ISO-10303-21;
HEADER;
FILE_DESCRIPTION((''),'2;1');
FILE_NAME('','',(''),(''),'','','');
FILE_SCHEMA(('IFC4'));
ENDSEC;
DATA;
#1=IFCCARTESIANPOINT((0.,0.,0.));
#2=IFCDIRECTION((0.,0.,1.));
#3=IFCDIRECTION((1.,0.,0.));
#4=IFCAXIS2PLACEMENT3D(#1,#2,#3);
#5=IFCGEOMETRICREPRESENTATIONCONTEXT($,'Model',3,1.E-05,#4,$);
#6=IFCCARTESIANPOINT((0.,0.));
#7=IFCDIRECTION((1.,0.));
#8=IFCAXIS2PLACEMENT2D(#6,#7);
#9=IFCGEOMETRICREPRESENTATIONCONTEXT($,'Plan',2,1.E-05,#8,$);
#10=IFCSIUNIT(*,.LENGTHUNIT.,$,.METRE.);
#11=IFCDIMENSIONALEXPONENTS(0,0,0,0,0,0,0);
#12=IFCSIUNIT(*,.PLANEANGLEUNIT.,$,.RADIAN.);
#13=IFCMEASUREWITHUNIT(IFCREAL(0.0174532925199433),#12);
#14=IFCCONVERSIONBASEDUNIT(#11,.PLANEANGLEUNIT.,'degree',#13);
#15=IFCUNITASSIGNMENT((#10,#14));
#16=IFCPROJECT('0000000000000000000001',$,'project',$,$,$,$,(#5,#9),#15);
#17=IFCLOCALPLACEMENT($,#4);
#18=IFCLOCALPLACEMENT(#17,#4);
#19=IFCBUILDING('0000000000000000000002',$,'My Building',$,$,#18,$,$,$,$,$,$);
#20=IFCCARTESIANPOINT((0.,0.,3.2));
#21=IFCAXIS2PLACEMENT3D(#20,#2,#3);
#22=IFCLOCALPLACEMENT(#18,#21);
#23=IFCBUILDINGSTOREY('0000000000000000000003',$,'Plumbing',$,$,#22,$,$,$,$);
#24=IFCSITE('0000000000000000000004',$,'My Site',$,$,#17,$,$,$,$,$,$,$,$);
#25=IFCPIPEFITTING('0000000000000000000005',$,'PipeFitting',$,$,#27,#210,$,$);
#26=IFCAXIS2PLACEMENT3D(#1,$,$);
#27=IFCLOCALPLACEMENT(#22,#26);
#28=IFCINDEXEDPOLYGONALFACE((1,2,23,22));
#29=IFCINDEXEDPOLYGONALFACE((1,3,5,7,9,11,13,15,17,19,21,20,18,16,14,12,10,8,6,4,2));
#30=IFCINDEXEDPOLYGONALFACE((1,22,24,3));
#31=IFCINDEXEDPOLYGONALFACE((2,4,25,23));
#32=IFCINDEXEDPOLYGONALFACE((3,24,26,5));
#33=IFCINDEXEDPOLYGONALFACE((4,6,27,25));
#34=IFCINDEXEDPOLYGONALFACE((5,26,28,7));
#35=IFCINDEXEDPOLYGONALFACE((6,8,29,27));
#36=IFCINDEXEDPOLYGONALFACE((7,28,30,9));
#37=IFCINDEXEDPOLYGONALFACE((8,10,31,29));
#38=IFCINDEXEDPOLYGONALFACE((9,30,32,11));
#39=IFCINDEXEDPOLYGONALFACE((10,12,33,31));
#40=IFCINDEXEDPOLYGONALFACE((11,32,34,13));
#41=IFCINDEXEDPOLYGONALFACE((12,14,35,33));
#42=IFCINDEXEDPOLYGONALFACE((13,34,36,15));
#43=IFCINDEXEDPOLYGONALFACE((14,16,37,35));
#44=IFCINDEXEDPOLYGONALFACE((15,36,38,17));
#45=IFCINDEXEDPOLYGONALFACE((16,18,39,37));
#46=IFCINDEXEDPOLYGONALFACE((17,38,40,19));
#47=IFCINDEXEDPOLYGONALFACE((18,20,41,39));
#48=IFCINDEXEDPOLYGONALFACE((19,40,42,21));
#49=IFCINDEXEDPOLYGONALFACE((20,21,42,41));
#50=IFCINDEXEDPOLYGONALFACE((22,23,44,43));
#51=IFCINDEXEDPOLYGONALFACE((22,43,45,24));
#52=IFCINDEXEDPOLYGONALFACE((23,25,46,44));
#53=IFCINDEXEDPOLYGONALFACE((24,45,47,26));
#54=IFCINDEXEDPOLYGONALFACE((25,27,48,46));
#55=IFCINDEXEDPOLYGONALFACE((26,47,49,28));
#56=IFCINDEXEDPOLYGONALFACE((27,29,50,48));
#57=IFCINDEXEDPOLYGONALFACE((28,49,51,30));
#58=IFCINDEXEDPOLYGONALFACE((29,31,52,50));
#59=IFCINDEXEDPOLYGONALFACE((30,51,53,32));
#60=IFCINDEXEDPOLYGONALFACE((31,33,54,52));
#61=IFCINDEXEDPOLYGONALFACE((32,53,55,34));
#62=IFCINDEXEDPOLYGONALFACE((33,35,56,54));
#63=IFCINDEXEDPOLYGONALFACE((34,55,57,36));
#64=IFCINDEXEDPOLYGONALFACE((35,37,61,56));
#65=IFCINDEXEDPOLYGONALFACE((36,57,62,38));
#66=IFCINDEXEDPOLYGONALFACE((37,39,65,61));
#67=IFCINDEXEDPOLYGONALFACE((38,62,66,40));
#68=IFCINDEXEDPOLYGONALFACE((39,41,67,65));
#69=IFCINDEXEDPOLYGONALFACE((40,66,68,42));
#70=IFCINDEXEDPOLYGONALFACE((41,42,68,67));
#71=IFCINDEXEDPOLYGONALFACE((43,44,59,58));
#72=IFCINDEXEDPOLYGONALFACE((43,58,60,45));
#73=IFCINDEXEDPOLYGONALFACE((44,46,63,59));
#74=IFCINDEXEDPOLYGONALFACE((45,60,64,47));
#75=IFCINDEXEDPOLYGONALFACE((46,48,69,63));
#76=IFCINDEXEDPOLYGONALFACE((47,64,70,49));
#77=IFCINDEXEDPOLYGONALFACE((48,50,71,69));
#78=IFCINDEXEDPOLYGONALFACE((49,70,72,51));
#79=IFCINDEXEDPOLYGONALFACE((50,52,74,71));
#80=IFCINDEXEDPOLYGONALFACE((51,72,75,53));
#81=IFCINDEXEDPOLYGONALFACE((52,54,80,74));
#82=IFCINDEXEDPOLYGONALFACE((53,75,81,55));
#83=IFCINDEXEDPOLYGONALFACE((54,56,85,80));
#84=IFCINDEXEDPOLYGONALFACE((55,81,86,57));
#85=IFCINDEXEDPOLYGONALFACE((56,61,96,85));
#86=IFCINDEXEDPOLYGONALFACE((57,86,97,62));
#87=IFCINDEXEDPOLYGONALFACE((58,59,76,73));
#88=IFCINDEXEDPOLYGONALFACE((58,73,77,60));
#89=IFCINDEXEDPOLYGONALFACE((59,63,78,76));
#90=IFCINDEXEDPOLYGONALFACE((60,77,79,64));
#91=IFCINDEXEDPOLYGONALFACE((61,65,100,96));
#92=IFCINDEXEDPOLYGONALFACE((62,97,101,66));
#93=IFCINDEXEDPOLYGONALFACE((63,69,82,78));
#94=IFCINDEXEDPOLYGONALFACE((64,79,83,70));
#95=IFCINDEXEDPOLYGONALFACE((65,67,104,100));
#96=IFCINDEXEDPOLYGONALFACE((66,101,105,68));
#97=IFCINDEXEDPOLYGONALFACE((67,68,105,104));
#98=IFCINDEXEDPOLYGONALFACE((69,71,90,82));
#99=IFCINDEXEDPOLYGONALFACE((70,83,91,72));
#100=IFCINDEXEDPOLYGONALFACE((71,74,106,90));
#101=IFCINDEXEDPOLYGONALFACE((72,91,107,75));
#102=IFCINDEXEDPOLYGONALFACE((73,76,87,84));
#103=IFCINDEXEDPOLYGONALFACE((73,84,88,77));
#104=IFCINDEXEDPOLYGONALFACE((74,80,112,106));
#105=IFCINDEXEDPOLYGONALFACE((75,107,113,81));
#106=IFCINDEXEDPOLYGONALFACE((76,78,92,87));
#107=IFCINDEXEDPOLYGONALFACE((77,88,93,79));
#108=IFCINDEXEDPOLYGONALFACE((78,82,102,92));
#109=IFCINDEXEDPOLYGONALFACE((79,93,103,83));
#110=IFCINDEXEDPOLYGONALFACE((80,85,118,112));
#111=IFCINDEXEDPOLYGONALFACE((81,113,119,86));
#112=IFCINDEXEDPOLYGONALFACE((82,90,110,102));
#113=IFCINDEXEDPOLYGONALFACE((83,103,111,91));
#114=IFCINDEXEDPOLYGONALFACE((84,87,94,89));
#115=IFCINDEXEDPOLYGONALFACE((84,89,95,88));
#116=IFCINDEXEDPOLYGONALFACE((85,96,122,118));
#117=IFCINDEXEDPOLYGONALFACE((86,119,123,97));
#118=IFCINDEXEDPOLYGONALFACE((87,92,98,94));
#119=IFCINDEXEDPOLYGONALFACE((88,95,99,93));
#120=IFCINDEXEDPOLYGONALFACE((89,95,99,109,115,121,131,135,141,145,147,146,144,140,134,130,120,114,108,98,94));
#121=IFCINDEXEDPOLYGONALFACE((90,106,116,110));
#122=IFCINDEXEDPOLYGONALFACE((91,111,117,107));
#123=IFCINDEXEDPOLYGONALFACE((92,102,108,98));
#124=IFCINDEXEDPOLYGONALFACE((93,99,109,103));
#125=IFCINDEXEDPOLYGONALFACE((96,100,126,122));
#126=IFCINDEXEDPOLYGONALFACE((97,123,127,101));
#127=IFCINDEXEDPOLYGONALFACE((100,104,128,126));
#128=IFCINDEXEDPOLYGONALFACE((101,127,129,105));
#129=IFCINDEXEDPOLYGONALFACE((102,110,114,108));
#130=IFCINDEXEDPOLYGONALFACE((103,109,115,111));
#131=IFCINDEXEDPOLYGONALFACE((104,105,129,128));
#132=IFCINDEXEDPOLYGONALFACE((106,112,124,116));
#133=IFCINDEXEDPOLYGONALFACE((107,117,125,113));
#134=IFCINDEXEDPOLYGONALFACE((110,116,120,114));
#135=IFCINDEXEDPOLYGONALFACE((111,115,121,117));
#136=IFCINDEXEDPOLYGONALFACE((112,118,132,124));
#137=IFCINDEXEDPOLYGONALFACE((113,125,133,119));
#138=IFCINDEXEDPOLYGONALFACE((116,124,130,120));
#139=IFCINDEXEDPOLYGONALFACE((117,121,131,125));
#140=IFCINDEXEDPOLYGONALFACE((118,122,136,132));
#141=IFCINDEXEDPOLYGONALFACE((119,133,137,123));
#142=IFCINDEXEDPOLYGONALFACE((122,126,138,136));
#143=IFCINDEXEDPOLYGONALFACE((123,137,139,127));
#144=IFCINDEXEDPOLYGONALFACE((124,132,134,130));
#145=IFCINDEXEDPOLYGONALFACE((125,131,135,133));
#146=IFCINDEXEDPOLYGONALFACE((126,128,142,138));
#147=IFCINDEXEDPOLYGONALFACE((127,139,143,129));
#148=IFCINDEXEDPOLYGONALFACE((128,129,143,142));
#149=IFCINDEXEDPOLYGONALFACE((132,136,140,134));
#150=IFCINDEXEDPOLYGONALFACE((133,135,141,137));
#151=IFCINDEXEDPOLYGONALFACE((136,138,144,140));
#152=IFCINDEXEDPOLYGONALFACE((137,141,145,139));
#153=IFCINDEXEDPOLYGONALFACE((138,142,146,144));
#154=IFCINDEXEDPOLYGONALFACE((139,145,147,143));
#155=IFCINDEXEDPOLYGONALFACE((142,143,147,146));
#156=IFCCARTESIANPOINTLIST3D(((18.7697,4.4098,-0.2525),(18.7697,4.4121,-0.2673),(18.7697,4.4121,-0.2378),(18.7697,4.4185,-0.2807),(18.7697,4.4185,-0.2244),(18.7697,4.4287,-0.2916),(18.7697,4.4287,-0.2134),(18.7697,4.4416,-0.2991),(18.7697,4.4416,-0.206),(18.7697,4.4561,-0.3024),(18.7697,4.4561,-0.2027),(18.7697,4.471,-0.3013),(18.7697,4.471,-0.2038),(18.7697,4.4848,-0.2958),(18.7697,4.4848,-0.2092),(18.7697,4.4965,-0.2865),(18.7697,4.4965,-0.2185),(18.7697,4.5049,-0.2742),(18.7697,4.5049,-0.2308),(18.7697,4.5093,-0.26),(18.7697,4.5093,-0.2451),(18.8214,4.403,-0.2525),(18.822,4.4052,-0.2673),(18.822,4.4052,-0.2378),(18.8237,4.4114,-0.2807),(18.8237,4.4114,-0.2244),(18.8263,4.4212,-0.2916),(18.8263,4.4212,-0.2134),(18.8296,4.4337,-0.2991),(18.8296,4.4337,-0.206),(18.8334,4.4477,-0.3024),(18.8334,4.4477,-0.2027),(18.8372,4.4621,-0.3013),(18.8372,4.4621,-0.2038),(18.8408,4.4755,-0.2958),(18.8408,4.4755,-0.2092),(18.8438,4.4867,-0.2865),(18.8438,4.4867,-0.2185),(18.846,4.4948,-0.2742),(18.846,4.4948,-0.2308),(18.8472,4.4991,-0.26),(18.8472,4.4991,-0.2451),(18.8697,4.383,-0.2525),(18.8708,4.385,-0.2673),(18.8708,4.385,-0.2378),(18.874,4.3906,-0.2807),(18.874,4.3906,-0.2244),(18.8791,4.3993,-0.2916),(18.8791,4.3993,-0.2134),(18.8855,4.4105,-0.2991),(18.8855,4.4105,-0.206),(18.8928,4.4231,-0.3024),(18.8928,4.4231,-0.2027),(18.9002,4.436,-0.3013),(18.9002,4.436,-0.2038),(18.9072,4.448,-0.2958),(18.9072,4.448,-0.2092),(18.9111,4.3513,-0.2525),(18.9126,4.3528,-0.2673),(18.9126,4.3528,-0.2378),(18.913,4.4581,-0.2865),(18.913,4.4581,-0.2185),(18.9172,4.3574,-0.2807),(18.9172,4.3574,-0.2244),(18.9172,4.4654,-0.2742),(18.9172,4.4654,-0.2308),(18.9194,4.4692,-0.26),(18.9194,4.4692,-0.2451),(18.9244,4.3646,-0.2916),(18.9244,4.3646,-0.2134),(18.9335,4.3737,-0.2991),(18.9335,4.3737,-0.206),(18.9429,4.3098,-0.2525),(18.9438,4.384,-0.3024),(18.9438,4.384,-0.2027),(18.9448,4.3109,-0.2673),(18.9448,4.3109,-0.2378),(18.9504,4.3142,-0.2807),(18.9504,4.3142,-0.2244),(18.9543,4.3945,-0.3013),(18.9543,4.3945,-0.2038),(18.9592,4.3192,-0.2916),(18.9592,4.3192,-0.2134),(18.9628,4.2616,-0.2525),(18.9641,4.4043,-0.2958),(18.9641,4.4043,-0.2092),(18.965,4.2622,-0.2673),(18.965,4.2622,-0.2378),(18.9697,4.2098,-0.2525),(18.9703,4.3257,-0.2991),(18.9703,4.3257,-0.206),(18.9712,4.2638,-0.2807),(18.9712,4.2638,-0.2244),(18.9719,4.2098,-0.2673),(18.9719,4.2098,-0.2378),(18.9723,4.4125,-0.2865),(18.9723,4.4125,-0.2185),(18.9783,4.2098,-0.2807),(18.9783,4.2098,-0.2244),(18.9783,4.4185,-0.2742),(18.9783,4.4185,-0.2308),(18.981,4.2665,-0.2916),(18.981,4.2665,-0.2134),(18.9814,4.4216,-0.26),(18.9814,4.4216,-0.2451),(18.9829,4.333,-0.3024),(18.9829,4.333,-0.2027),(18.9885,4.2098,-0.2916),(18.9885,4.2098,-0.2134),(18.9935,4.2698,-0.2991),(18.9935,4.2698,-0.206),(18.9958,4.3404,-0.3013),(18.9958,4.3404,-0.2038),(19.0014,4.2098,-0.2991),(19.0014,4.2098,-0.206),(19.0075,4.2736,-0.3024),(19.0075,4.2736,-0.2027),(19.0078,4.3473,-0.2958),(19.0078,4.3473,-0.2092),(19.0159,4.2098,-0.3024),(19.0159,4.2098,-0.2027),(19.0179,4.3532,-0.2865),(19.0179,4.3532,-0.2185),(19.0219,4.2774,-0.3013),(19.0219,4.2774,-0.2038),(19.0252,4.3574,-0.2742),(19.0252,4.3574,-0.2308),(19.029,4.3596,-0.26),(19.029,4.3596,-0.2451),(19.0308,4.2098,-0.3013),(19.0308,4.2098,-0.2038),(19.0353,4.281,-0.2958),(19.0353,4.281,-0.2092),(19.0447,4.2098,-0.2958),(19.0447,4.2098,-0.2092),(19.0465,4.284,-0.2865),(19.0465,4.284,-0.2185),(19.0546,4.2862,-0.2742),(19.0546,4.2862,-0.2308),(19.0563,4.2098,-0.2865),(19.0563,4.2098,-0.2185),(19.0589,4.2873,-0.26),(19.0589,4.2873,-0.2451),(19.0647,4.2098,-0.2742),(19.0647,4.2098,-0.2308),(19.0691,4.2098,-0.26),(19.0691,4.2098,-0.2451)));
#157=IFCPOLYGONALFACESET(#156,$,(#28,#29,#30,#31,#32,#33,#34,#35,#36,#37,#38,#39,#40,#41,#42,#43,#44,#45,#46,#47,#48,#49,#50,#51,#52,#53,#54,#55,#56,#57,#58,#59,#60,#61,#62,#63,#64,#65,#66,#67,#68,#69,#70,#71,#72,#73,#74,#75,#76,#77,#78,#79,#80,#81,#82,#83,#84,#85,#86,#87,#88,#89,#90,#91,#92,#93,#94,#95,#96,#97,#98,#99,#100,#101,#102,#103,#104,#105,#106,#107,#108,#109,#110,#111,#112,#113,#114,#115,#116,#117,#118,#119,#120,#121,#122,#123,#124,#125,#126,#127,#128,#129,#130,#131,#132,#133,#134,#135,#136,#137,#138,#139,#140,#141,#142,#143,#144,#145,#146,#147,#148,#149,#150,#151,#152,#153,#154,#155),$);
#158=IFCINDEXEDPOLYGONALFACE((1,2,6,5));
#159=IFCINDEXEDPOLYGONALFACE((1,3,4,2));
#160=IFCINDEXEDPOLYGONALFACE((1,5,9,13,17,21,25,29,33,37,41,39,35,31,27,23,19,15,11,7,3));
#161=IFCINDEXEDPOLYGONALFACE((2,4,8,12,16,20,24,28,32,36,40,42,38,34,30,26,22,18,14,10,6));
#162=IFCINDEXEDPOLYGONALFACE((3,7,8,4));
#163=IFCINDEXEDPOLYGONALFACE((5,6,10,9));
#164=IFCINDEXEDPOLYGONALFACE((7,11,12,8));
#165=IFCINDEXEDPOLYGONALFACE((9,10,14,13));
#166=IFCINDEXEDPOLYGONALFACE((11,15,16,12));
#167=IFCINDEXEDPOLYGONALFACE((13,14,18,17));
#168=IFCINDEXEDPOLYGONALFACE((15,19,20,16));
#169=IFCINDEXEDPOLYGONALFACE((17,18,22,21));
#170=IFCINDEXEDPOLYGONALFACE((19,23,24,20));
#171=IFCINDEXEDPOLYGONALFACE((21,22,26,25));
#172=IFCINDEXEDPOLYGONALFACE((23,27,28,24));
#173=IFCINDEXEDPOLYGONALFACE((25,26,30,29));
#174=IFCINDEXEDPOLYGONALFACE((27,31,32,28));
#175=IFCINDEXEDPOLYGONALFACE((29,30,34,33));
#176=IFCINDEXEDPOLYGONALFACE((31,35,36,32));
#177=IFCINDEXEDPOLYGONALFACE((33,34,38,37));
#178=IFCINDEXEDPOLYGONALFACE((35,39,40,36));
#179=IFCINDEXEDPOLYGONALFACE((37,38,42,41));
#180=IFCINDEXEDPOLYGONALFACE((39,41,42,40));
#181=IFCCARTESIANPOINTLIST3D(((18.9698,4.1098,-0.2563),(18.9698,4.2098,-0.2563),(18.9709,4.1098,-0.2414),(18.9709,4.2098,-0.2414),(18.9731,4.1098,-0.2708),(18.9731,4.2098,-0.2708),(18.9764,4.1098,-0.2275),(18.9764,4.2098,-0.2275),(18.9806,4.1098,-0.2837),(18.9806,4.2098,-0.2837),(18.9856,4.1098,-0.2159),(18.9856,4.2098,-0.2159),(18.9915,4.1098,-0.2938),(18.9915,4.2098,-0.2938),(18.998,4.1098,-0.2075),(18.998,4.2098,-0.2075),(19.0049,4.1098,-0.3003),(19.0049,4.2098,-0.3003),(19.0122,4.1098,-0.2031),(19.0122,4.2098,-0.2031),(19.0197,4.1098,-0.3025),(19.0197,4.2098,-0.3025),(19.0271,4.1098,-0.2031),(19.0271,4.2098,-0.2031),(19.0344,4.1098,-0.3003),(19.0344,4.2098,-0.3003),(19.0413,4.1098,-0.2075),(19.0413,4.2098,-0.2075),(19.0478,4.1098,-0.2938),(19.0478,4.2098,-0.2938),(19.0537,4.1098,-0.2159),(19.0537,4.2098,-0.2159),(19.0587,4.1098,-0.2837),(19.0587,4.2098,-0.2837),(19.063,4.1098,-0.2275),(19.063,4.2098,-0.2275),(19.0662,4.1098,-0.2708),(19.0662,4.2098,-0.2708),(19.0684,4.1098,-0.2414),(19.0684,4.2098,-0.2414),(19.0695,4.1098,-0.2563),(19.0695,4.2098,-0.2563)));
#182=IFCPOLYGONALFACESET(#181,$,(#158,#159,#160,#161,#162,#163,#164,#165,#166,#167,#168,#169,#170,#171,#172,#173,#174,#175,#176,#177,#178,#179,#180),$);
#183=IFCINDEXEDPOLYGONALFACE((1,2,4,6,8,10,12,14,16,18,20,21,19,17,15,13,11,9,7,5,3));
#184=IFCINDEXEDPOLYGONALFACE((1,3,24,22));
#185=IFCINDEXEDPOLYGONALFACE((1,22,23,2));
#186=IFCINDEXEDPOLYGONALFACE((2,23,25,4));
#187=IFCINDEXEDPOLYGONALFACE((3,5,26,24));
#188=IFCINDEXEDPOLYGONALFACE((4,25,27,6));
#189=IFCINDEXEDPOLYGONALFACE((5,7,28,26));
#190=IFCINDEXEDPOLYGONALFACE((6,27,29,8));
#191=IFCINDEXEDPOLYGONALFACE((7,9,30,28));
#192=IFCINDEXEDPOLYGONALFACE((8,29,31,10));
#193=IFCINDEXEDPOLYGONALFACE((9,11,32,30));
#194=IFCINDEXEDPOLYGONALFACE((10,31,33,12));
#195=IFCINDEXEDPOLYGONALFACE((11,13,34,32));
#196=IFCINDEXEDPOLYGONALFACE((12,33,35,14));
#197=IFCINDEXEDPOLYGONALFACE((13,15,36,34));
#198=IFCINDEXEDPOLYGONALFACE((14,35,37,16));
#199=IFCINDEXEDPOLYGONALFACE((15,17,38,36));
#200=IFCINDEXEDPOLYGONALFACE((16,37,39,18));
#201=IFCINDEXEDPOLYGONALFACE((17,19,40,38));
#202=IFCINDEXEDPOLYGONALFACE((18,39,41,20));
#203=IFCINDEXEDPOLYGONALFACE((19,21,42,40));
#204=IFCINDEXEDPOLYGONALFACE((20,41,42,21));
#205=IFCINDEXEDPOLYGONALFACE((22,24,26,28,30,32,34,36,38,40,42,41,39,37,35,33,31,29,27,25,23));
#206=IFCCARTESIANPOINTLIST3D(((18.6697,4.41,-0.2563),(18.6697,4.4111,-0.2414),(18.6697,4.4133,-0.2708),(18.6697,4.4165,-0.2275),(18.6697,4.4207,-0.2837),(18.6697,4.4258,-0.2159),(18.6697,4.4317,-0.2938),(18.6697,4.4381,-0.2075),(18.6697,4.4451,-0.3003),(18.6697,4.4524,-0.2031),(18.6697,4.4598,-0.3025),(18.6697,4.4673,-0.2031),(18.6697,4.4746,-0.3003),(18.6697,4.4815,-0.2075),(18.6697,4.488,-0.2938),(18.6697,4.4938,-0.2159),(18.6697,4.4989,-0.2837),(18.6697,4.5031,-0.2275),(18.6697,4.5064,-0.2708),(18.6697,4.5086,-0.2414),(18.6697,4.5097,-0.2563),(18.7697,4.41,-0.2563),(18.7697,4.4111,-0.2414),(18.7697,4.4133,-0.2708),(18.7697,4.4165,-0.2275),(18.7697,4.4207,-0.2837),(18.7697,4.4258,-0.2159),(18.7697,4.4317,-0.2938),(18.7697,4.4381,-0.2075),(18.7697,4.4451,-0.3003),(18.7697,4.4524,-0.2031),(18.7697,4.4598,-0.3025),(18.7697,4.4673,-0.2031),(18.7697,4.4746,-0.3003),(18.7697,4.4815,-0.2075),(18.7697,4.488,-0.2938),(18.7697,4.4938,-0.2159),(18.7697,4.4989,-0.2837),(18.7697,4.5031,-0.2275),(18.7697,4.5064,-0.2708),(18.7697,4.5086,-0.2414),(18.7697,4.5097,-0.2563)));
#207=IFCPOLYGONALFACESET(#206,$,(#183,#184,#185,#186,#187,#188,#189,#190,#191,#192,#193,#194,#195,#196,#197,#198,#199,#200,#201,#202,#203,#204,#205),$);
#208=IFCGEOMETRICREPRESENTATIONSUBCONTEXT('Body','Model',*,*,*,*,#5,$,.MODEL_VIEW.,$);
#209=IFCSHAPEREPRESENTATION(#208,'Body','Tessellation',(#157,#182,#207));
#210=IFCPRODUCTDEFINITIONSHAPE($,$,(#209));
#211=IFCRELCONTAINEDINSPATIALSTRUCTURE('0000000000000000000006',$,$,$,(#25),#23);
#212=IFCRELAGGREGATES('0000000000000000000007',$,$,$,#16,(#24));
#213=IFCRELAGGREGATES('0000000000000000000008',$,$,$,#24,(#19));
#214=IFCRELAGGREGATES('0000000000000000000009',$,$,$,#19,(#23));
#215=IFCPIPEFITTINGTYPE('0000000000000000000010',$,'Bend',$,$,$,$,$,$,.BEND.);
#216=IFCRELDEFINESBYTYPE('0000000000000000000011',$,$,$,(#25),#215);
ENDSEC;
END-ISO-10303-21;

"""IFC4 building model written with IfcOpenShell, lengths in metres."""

from ifc_helpers import new_model, entity, si_unit, converted_unit, frame, origin_with_axes, origin_2d_with_axis, place, context, subcontext, project, spatial, circle, extrude, source, transform, mapped, type_object, type_shapes, element, save


model = new_model("IFC4")

# Units and contexts
model_context = context("Model", 3, precision=1e-05, world=origin_with_axes())
plan_context = context("Plan", 2, precision=1e-05, world=origin_2d_with_axis())
body_context = subcontext(model_context, "Body", "Model", "MODEL_VIEW")
ifc_project = project(units=[si_unit("LENGTHUNIT", "METRE"), converted_unit("PLANEANGLEUNIT", "degree", entity("IfcReal", 0.0174532925199433), si_unit("PLANEANGLEUNIT", "RADIAN"), dimensions=[0, 0, 0, 0, 0, 0, 0])], contexts=[model_context, plan_context])

# Site, building, storey
site_placement = place(None, origin_with_axes())
site = spatial("IfcSite", under=ifc_project, at=site_placement, Name="My Site")
building_placement = place(site_placement, origin_with_axes())
building = spatial("IfcBuilding", under=site, at=building_placement, Name="My Building")
storey_placement = place(building_placement, frame((0.0, 0.0, 3.2), z_axis=(0.0, 0.0, 1.0), x_axis=(1.0, 0.0, 0.0)))
storey = spatial("IfcBuildingStorey", under=building, at=storey_placement, Name="Plumbing")

# Pipe fitting
pipe_fitting_type = type_object("IfcPipeFittingType", Name="Bend", PredefinedType="BEND")
shared_shape = source(origin_with_axes(), body_context, "Body", "SolidModel", [
    entity("IfcSweptDiskSolid", entity("IfcIndexedPolyCurve", entity("IfcCartesianPointList3D", [[0.0, 0.0, -0.1], [0.0, -0.0732, -0.2768], [0.0, -0.25, -0.35]]), [entity("IfcArcIndex", [1, 2, 3])]), 0.05),
    extrude(circle(Radius=0.05), origin_with_axes(), (0.0, 0.0, -1.0), 0.1),
    extrude(circle(Radius=0.05), frame((0.0, -0.25, -0.35), z_axis=(0.0, -1.0, 0.0), x_axis=(1.0, 0.0, 0.0)), (0.0, 0.0, 1.0), 0.1),
])
type_shapes(pipe_fitting_type, [shared_shape])
for number, where, z_axis, x_axis, name in (
    (1, (19.0197, 4.1098, -0.2525), (0.0, -1.0, 0.0), (0.0, 0.0, -1.0), "PipeFitting"),
):
    element("IfcPipeFitting", number, at=place(storey_placement, frame(where, z_axis=z_axis, x_axis=x_axis)), inside=storey, type_object=pipe_fitting_type, Name=name, context=body_context, shape_type="MappedRepresentation", body=[
        mapped(shared_shape, transform((0.0, 0.0, 0.0), x_axis=(1.0, 0.0, 0.0), y_axis=(0.0, 1.0, 0.0), z_axis=(0.0, 0.0, 1.0), scale=1.0)),
    ])

save(model, "model.ifc")
